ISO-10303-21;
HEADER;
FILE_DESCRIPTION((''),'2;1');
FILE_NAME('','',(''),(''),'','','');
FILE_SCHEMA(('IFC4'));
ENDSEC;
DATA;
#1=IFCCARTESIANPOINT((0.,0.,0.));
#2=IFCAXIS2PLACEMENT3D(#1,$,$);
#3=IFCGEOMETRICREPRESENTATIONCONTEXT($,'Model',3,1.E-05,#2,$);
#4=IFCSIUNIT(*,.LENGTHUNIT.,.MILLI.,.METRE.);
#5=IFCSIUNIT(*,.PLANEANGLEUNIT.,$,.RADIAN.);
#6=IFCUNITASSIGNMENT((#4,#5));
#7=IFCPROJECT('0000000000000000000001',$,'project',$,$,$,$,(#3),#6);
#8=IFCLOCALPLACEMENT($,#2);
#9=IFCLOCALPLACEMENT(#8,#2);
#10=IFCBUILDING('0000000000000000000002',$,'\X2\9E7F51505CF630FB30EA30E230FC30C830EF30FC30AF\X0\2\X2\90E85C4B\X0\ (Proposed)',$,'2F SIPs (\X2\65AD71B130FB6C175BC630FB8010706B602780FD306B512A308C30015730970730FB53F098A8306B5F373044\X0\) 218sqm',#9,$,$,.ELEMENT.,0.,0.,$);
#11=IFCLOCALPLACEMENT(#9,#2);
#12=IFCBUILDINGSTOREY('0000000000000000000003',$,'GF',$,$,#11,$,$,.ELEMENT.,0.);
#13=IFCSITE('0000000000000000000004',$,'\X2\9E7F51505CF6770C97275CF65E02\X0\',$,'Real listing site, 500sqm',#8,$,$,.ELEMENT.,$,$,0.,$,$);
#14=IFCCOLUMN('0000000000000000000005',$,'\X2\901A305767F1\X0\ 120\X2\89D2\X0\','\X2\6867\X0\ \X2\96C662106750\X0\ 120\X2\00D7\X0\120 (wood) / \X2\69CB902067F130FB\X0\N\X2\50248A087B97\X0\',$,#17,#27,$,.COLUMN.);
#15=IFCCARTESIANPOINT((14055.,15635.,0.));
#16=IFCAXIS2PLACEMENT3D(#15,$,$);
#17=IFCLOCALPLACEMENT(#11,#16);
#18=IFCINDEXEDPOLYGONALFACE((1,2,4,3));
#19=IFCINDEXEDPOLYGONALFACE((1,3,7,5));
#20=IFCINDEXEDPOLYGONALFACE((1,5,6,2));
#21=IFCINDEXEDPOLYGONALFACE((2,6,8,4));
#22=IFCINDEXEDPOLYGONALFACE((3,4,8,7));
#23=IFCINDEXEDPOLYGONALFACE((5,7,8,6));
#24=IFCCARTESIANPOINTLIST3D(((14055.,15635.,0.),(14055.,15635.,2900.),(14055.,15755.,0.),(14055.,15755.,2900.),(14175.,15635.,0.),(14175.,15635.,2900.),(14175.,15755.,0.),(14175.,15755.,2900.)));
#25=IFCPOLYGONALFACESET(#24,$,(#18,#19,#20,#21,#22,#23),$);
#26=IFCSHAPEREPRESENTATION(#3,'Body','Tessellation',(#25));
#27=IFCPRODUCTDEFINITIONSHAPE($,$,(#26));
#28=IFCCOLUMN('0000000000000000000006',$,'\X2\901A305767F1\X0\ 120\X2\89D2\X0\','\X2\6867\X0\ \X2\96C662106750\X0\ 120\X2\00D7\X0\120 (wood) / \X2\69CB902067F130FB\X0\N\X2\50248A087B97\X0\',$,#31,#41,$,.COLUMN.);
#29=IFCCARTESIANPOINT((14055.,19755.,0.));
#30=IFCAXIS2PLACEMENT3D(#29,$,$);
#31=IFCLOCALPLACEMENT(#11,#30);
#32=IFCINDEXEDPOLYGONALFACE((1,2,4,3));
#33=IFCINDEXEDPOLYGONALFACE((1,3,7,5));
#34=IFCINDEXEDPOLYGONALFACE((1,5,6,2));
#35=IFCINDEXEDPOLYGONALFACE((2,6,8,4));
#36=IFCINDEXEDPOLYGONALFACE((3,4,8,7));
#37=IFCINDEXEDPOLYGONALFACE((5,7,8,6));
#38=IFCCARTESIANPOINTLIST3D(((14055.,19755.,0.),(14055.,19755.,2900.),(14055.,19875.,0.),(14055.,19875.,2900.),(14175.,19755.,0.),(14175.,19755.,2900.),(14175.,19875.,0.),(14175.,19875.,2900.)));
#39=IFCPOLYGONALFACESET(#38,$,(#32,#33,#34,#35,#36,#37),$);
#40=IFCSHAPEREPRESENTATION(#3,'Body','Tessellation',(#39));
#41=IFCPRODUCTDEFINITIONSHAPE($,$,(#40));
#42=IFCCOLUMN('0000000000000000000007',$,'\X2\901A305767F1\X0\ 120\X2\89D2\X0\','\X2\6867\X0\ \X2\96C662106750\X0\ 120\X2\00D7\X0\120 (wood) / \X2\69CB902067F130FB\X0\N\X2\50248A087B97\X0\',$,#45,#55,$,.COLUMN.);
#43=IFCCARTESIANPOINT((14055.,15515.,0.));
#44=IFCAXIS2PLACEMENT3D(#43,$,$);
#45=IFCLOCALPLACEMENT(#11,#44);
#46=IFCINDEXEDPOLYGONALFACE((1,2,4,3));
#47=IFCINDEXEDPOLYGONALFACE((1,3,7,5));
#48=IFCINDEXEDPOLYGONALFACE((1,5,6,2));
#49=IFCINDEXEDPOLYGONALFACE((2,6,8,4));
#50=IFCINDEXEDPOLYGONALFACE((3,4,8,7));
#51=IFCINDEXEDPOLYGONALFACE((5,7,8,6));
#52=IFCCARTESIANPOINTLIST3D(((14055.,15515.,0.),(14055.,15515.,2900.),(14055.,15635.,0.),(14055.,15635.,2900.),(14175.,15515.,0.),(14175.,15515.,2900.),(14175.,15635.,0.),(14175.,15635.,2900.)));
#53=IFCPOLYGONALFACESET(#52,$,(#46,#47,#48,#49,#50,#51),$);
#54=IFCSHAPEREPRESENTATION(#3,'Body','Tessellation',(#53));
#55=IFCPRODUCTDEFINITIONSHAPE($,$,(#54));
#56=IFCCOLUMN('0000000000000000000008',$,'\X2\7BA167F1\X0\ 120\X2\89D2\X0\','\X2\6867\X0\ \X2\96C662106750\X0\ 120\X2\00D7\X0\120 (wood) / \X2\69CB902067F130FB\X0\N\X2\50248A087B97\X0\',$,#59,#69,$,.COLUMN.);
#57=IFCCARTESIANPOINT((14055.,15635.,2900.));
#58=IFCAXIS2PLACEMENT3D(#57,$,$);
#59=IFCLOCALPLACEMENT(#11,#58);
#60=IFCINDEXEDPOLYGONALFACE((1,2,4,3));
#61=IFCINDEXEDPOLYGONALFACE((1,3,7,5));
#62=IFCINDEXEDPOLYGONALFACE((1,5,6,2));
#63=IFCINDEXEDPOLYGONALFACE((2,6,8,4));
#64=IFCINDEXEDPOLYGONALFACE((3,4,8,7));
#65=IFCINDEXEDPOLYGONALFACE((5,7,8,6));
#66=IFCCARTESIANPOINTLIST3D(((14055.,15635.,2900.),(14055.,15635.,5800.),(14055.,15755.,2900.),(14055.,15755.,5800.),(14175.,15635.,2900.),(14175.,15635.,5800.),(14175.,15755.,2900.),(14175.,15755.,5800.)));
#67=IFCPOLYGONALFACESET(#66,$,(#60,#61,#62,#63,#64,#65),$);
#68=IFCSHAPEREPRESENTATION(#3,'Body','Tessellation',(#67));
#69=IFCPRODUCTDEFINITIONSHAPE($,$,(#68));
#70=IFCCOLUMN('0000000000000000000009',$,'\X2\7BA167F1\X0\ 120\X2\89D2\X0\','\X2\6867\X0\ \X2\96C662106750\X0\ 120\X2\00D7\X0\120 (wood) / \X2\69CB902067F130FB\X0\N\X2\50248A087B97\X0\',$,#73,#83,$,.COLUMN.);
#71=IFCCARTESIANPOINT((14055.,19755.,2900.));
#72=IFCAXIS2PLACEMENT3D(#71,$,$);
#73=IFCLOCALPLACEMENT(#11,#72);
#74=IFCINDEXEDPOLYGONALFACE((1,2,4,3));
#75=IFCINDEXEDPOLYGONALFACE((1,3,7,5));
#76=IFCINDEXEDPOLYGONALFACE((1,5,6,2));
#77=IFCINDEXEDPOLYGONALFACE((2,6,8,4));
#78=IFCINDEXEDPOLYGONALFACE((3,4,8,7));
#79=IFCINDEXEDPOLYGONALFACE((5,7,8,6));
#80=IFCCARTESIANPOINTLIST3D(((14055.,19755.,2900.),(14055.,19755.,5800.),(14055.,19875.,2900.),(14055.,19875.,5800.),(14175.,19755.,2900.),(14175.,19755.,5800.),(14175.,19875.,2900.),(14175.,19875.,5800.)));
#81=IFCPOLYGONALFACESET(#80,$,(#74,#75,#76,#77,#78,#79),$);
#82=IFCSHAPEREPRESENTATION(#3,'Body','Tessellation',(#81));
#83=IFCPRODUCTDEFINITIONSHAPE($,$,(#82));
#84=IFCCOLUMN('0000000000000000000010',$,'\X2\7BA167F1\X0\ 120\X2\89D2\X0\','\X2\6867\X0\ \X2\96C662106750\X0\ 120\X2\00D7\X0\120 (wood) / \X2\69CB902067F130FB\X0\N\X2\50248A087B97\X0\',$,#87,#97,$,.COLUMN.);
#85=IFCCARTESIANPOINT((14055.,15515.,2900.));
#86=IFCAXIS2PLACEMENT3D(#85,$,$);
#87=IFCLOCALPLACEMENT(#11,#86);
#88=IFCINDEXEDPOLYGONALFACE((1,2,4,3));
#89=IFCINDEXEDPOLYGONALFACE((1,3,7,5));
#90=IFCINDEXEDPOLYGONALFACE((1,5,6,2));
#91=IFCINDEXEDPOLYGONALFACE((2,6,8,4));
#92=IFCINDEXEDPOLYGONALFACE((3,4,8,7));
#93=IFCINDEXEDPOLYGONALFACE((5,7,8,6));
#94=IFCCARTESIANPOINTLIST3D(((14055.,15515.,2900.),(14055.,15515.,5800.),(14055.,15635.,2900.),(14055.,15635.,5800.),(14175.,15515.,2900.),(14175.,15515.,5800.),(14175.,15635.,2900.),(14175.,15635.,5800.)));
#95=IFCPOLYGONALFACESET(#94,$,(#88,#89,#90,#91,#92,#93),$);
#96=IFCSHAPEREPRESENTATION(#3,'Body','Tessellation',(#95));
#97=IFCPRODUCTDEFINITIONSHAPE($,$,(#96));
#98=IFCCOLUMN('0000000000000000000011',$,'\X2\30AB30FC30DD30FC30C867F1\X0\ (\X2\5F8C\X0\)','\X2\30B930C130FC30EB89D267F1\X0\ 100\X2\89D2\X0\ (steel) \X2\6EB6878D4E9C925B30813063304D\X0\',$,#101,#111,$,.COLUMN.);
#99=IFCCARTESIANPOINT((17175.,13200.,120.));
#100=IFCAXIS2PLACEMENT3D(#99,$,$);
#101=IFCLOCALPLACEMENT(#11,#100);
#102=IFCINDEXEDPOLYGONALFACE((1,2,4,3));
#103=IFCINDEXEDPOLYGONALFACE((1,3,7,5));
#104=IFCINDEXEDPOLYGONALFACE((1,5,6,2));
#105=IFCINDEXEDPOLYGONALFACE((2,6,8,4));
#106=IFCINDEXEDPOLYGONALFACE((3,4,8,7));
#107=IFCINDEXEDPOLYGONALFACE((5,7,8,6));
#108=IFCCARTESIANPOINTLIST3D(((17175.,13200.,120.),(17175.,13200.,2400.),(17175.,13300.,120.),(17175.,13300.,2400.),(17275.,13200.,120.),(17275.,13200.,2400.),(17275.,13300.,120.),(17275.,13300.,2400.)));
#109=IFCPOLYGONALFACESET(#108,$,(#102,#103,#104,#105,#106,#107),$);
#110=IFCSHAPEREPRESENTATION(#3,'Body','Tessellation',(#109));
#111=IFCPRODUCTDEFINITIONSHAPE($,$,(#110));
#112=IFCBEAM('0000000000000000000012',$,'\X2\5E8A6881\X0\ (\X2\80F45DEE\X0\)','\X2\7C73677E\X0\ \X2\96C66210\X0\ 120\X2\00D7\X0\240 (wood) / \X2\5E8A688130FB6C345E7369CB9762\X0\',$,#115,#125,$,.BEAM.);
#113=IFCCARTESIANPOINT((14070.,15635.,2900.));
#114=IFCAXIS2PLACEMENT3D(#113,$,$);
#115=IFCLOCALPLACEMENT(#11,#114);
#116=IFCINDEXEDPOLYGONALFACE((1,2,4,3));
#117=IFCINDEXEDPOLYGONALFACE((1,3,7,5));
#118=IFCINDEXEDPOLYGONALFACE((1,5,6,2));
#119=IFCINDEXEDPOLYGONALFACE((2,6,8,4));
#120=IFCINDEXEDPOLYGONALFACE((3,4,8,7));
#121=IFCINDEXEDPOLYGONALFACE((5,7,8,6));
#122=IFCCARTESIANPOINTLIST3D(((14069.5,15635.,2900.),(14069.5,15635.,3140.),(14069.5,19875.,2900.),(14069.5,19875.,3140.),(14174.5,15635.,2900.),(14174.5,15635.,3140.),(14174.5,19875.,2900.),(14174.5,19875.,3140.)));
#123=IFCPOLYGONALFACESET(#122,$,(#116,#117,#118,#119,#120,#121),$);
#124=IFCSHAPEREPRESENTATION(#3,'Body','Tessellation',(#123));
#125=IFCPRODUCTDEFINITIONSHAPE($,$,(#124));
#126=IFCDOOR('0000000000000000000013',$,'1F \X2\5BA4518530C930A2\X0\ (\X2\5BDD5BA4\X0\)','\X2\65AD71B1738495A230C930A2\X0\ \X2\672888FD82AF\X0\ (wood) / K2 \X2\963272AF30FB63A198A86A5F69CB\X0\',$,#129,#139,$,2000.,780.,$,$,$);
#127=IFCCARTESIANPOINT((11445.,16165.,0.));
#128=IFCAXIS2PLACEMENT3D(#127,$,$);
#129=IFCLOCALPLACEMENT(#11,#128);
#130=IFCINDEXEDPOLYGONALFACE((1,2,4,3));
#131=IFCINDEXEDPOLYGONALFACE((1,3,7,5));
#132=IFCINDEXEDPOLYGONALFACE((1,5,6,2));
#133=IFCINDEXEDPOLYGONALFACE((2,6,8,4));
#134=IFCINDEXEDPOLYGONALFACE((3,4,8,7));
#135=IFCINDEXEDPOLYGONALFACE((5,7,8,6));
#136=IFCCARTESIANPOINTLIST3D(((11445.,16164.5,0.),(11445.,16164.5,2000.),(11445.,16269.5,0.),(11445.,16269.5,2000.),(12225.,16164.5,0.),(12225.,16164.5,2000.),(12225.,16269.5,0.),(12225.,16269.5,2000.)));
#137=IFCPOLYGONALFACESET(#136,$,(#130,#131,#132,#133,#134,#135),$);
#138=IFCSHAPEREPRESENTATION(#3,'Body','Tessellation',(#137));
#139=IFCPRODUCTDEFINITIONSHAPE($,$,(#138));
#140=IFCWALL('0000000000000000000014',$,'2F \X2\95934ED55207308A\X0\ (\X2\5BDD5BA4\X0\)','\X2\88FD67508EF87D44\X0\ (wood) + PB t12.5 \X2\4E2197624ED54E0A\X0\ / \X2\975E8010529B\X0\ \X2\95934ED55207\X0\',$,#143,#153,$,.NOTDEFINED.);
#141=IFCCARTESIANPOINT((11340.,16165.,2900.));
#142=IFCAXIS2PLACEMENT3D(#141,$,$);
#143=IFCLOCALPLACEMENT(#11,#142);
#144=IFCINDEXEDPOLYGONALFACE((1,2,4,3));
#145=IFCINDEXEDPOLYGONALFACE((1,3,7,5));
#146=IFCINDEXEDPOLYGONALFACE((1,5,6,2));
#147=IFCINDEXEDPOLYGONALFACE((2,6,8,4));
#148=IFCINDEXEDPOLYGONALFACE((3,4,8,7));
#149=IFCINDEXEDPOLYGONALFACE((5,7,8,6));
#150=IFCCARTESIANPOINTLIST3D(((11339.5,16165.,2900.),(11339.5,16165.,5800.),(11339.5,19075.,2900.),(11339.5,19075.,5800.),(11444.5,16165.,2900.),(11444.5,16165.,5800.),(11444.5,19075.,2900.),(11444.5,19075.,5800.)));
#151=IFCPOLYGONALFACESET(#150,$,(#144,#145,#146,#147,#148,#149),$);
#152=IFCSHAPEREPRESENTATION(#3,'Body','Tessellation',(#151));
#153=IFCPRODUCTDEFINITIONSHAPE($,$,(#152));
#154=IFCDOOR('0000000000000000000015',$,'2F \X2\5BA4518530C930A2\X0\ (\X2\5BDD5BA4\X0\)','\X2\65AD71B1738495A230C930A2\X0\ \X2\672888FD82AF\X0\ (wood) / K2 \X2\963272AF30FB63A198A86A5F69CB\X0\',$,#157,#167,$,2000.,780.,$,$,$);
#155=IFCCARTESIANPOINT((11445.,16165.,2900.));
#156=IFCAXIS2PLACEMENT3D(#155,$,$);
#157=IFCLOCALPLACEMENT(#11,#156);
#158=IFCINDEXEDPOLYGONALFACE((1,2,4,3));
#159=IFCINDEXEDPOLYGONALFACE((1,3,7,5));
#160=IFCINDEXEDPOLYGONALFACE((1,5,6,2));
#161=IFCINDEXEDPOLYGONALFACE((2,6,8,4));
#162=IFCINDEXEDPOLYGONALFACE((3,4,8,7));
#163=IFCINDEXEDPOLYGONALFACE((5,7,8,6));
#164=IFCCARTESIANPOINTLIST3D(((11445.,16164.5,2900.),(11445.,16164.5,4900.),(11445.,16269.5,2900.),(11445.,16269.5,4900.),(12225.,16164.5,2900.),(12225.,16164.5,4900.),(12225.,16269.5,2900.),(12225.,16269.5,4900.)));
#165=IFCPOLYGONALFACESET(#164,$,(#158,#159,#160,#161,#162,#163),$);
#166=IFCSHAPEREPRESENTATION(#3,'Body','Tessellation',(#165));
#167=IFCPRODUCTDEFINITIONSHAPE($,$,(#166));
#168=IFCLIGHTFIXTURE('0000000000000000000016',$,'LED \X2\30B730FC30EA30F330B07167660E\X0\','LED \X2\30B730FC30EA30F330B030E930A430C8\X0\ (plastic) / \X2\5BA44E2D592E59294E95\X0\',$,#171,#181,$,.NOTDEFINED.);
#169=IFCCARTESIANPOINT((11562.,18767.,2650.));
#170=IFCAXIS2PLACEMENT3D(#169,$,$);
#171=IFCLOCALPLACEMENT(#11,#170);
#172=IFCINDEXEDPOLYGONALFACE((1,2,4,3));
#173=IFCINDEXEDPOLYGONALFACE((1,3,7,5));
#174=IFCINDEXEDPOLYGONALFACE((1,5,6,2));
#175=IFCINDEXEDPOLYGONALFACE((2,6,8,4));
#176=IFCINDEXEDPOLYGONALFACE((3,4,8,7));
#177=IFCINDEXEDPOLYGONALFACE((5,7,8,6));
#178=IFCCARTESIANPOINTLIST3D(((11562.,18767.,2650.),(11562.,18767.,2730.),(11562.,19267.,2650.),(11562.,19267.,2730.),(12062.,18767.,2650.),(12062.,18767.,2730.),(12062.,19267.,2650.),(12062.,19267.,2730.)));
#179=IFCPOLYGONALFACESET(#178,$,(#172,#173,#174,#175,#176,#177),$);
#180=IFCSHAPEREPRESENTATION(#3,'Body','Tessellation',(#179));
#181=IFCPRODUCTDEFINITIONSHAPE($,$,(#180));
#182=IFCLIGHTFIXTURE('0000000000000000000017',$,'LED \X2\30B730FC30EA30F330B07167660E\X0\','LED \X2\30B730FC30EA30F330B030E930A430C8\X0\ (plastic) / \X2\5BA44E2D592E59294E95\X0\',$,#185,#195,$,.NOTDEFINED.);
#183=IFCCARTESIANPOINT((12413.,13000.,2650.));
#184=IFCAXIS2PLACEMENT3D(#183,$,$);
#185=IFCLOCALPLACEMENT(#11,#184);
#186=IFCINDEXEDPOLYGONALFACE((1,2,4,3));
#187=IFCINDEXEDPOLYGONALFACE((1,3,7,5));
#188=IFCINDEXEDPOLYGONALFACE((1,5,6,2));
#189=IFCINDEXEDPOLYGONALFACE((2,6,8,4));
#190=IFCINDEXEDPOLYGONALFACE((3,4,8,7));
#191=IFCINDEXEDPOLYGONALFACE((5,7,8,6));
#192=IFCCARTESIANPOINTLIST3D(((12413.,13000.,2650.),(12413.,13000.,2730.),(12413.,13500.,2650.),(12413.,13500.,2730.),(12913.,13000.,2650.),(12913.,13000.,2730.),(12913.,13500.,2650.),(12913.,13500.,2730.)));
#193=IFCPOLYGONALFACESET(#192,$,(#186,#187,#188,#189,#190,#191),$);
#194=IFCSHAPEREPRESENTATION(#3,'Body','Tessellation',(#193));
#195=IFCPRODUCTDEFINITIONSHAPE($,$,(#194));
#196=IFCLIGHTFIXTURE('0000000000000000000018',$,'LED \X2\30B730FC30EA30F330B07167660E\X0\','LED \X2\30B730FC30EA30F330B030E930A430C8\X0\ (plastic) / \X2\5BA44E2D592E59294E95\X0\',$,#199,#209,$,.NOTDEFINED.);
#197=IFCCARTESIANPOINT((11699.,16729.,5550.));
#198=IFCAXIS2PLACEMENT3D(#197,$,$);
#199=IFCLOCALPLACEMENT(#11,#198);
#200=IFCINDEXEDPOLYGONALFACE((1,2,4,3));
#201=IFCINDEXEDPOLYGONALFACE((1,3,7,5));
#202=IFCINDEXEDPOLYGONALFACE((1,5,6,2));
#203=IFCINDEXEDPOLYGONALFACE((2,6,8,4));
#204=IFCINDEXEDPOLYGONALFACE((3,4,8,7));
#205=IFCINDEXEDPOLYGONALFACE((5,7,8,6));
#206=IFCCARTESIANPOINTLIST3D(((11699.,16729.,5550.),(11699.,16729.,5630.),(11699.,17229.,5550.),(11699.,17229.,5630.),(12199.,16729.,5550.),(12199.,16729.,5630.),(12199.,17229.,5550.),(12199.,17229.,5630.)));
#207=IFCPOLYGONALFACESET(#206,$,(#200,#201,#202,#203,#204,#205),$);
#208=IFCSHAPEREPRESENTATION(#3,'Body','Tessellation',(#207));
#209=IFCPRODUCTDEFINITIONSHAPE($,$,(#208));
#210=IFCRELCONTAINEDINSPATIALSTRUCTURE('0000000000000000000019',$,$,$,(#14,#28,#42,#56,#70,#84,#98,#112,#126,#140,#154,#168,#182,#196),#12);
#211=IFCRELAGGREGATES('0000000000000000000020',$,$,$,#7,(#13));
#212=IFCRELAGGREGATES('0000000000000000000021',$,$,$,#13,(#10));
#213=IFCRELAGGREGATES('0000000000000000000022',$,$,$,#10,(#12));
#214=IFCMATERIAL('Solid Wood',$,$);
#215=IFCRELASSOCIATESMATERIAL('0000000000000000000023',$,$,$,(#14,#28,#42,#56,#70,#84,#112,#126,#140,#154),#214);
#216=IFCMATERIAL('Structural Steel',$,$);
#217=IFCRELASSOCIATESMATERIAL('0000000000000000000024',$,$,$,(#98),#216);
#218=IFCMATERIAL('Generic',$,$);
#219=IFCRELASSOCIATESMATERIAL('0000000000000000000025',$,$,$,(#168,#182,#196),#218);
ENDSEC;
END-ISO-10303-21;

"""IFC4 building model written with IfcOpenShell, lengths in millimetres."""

from ifc_helpers import new_model, si_unit, frame, frame_2d, origin, place, context, project, spatial, rectangle, extrude, material, element, save


model = new_model("IFC4")

# Units and contexts
model_context = context("Model", 3, precision=1e-05, world=origin())
ifc_project = project(units=[si_unit("LENGTHUNIT", "METRE", prefix="MILLI"), si_unit("PLANEANGLEUNIT", "RADIAN")], contexts=[model_context])

# Site, building, storey
site_placement = place(None, origin())
site = spatial("IfcSite", under=ifc_project, at=site_placement, Name="鹿児島県霧島市", ObjectType="Real listing site, 500sqm", CompositionType="ELEMENT", RefElevation=0.0)
building_placement = place(site_placement, origin())
building = spatial("IfcBuilding", under=site, at=building_placement, Name="鹿児島・リモートワーク2部屋 (Proposed)", ObjectType="2F SIPs (断熱・気密・耐火性能に優れ、地震・台風に強い) 218sqm", CompositionType="ELEMENT", ElevationOfRefHeight=0.0, ElevationOfTerrain=0.0)
storey_placement = place(building_placement, origin())
storey = spatial("IfcBuildingStorey", under=building, at=storey_placement, Name="GF", CompositionType="ELEMENT", Elevation=0.0)

# Columns
ifc_material_1 = material(Name="Solid Wood")
column_1_placement = place(storey_placement, frame((14055.0, 15635.0, 0.0)))
element("IfcColumn", 1, at=column_1_placement, inside=storey, material=ifc_material_1, Name="通し柱 120角", Description="桧 集成材 120×120 (wood) / 構造柱・N値計算", PredefinedType="COLUMN", context=model_context, shape_type="SweptSolid", body=[
    extrude(rectangle(XDim=120.0, YDim=120.0, at=frame_2d((60.0, 60.0))), frame((14055.0, 15635.0, 0.0)), (0.0, 0.0, 1.0), 2900.0),
])
column_2_placement = place(storey_placement, frame((14055.0, 19755.0, 0.0)))
element("IfcColumn", 2, at=column_2_placement, inside=storey, material=ifc_material_1, Name="通し柱 120角", Description="桧 集成材 120×120 (wood) / 構造柱・N値計算", PredefinedType="COLUMN", context=model_context, shape_type="SweptSolid", body=[
    extrude(rectangle(XDim=120.0, YDim=120.0, at=frame_2d((60.0, 60.0))), frame((14055.0, 19755.0, 0.0)), (0.0, 0.0, 1.0), 2900.0),
])
column_3_placement = place(storey_placement, frame((14055.0, 15515.0, 0.0)))
element("IfcColumn", 3, at=column_3_placement, inside=storey, material=ifc_material_1, Name="通し柱 120角", Description="桧 集成材 120×120 (wood) / 構造柱・N値計算", PredefinedType="COLUMN", context=model_context, shape_type="SweptSolid", body=[
    extrude(rectangle(XDim=120.0, YDim=120.0, at=frame_2d((60.0, 60.0))), frame((14055.0, 15515.0, 0.0)), (0.0, 0.0, 1.0), 2900.0),
])
column_4_placement = place(storey_placement, frame((14055.0, 15635.0, 2900.0)))
element("IfcColumn", 4, at=column_4_placement, inside=storey, material=ifc_material_1, Name="管柱 120角", Description="桧 集成材 120×120 (wood) / 構造柱・N値計算", PredefinedType="COLUMN", context=model_context, shape_type="SweptSolid", body=[
    extrude(rectangle(XDim=120.0, YDim=120.0, at=frame_2d((60.0, 60.0))), frame((14055.0, 15635.0, 2900.0)), (0.0, 0.0, 1.0), 2900.0),
])
column_5_placement = place(storey_placement, frame((14055.0, 19755.0, 2900.0)))
element("IfcColumn", 5, at=column_5_placement, inside=storey, material=ifc_material_1, Name="管柱 120角", Description="桧 集成材 120×120 (wood) / 構造柱・N値計算", PredefinedType="COLUMN", context=model_context, shape_type="SweptSolid", body=[
    extrude(rectangle(XDim=120.0, YDim=120.0, at=frame_2d((60.0, 60.0))), frame((14055.0, 19755.0, 2900.0)), (0.0, 0.0, 1.0), 2900.0),
])
column_6_placement = place(storey_placement, frame((14055.0, 15515.0, 2900.0)))
element("IfcColumn", 6, at=column_6_placement, inside=storey, material=ifc_material_1, Name="管柱 120角", Description="桧 集成材 120×120 (wood) / 構造柱・N値計算", PredefinedType="COLUMN", context=model_context, shape_type="SweptSolid", body=[
    extrude(rectangle(XDim=120.0, YDim=120.0, at=frame_2d((60.0, 60.0))), frame((14055.0, 15515.0, 2900.0)), (0.0, 0.0, 1.0), 2900.0),
])
ifc_material_2 = material(Name="Structural Steel")
column_7_placement = place(storey_placement, frame((17175.0, 13200.0, 120.0)))
element("IfcColumn", 7, at=column_7_placement, inside=storey, material=ifc_material_2, Name="カーポート柱 (後)", Description="スチール角柱 100角 (steel) 溶融亜鉛めっき", PredefinedType="COLUMN", context=model_context, shape_type="SweptSolid", body=[
    extrude(rectangle(XDim=100.0, YDim=100.0, at=frame_2d((50.0, 50.0))), frame((17175.0, 13200.0, 120.0)), (0.0, 0.0, 1.0), 2280.0),
])

# Beam
beam_1_placement = place(storey_placement, frame((14070.0, 15635.0, 2900.0)))
element("IfcBeam", 8, at=beam_1_placement, inside=storey, material=ifc_material_1, Name="床梁 (胴差)", Description="米松 集成 120×240 (wood) / 床梁・水平構面", PredefinedType="BEAM", context=model_context, shape_type="SweptSolid", body=[
    extrude(rectangle(XDim=105.0, YDim=4240.0, at=frame_2d((52.0, 2120.0))), frame((14070.0, 15635.0, 2900.0)), (0.0, 0.0, 1.0), 240.0),
])

# Door
door_1_placement = place(storey_placement, frame((11445.0, 16165.0, 0.0)))
element("IfcDoor", 9, at=door_1_placement, inside=storey, material=ifc_material_1, Name="1F 室内ドア (寝室)", Description="断熱玄関ドア 木製芯 (wood) / K2 防犯・採風機構", OverallHeight=2000.0, OverallWidth=780.0, context=model_context, shape_type="SweptSolid", body=[
    extrude(rectangle(XDim=780.0, YDim=105.0, at=frame_2d((390.0, 52.0))), frame((11445.0, 16165.0, 0.0)), (0.0, 0.0, 1.0), 2000.0),
])

# Wall
wall_placement = place(storey_placement, frame((11340.0, 16165.0, 2900.0)))
element("IfcWall", 10, at=wall_placement, inside=storey, material=ifc_material_1, Name="2F 間仕切り (寝室)", Description="製材軸組 (wood) + PB t12.5 両面仕上 / 非耐力 間仕切", PredefinedType="NOTDEFINED", context=model_context, shape_type="SweptSolid", body=[
    extrude(rectangle(XDim=105.0, YDim=2910.0, at=frame_2d((52.0, 1455.0))), frame((11340.0, 16165.0, 2900.0)), (0.0, 0.0, 1.0), 2900.0),
])

# Door
door_2_placement = place(storey_placement, frame((11445.0, 16165.0, 2900.0)))
element("IfcDoor", 11, at=door_2_placement, inside=storey, material=ifc_material_1, Name="2F 室内ドア (寝室)", Description="断熱玄関ドア 木製芯 (wood) / K2 防犯・採風機構", OverallHeight=2000.0, OverallWidth=780.0, context=model_context, shape_type="SweptSolid", body=[
    extrude(rectangle(XDim=780.0, YDim=105.0, at=frame_2d((390.0, 52.0))), frame((11445.0, 16165.0, 2900.0)), (0.0, 0.0, 1.0), 2000.0),
])

# Light fixtures
ifc_material_3 = material(Name="Generic")
light_fixture_1_placement = place(storey_placement, frame((11562.0, 18767.0, 2650.0)))
element("IfcLightFixture", 12, at=light_fixture_1_placement, inside=storey, material=ifc_material_3, Name="LED シーリング照明", Description="LED シーリングライト (plastic) / 室中央天井", PredefinedType="NOTDEFINED", context=model_context, shape_type="SweptSolid", body=[
    extrude(rectangle(XDim=500.0, YDim=500.0, at=frame_2d((250.0, 250.0))), frame((11562.0, 18767.0, 2650.0)), (0.0, 0.0, 1.0), 80.0),
])
light_fixture_2_placement = place(storey_placement, frame((12413.0, 13000.0, 2650.0)))
element("IfcLightFixture", 13, at=light_fixture_2_placement, inside=storey, material=ifc_material_3, Name="LED シーリング照明", Description="LED シーリングライト (plastic) / 室中央天井", PredefinedType="NOTDEFINED", context=model_context, shape_type="SweptSolid", body=[
    extrude(rectangle(XDim=500.0, YDim=500.0, at=frame_2d((250.0, 250.0))), frame((12413.0, 13000.0, 2650.0)), (0.0, 0.0, 1.0), 80.0),
])
light_fixture_3_placement = place(storey_placement, frame((11699.0, 16729.0, 5550.0)))
element("IfcLightFixture", 14, at=light_fixture_3_placement, inside=storey, material=ifc_material_3, Name="LED シーリング照明", Description="LED シーリングライト (plastic) / 室中央天井", PredefinedType="NOTDEFINED", context=model_context, shape_type="SweptSolid", body=[
    extrude(rectangle(XDim=500.0, YDim=500.0, at=frame_2d((250.0, 250.0))), frame((11699.0, 16729.0, 5550.0)), (0.0, 0.0, 1.0), 80.0),
])

save(model, "model.ifc")
